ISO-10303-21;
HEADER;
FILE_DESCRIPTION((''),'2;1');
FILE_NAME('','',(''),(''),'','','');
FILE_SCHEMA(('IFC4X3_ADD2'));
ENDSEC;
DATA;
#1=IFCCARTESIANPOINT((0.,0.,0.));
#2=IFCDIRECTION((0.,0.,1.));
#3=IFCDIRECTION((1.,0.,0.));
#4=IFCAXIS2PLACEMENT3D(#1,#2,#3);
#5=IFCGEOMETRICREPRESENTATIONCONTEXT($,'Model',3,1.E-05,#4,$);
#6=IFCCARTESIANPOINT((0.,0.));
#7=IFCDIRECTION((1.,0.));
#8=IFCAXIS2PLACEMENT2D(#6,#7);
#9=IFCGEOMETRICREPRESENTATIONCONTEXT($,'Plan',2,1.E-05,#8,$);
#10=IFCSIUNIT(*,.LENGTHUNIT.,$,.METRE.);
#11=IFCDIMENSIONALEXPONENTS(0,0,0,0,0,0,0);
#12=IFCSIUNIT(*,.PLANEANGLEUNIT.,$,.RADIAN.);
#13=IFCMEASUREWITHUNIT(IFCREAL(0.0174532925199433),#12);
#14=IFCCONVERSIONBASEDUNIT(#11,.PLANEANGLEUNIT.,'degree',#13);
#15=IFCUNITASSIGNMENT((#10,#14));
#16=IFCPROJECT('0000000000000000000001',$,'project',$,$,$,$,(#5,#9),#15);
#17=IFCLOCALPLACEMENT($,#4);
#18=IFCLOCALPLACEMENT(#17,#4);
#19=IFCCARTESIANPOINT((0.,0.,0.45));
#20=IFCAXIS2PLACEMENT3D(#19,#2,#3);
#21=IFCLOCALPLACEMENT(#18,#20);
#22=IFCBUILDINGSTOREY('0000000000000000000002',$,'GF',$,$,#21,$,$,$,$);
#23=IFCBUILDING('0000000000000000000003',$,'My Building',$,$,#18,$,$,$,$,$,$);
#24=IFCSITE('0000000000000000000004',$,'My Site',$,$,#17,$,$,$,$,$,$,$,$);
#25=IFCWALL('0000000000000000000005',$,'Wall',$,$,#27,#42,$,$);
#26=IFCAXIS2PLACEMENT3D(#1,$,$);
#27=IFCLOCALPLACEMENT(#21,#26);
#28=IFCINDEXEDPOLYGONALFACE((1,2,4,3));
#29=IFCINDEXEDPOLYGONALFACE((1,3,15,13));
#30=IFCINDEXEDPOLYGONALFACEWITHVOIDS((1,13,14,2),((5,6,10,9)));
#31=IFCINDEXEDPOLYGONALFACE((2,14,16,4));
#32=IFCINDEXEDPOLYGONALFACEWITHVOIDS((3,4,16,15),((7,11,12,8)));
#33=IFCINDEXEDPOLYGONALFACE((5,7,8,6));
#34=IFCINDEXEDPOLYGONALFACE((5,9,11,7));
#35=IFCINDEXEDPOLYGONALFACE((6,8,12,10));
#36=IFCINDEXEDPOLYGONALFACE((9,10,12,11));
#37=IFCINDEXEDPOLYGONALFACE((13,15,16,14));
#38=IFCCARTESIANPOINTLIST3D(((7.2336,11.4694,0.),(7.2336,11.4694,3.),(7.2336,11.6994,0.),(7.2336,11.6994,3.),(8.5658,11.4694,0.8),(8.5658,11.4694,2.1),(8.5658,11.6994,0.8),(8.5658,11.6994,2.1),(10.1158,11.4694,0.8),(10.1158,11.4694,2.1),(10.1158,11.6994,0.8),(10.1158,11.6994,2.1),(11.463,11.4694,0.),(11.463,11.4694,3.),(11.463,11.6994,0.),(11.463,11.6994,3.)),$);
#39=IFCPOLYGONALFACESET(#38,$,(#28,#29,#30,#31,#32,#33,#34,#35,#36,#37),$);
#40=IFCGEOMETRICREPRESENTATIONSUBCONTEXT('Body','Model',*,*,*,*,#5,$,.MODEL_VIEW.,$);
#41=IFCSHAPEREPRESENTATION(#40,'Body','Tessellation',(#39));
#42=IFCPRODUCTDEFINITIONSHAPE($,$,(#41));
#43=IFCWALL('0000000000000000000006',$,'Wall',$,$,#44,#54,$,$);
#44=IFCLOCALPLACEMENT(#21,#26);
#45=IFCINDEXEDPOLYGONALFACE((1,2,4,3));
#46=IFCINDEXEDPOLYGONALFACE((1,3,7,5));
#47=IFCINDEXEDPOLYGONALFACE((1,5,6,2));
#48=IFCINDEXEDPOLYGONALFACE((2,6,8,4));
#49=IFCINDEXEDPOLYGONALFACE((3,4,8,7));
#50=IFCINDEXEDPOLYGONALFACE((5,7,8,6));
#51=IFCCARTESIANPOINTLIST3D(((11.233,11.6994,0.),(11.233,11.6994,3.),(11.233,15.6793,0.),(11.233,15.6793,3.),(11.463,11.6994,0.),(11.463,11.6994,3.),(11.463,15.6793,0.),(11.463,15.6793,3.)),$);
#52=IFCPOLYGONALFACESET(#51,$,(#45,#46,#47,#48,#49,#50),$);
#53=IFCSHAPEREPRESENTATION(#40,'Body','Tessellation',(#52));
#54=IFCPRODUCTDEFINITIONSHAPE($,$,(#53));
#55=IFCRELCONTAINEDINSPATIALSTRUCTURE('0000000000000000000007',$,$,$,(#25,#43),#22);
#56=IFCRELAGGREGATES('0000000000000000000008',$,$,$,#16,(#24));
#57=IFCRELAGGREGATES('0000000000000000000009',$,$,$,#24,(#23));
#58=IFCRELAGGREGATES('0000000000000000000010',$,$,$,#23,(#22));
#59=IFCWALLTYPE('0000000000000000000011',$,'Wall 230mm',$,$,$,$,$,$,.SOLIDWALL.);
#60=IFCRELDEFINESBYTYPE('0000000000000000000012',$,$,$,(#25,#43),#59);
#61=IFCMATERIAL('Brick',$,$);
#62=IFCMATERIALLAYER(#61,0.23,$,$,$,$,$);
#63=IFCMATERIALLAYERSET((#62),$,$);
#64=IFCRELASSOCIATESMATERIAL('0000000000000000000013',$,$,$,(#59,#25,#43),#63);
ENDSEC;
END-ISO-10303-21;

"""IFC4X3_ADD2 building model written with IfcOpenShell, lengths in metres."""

from ifc_helpers import new_model, entity, si_unit, converted_unit, frame, origin_with_axes, origin_2d_with_axis, place, context, subcontext, project, spatial, line, indexed_curve, outline, extrude, source, transform, mapped, material, layer, layer_set, layer_usage, type_object, element, save


model = new_model("IFC4X3_ADD2")

# Units and contexts
model_context = context("Model", 3, precision=1e-05, world=origin_with_axes())
plan_context = context("Plan", 2, precision=1e-05, world=origin_2d_with_axis())
body_context_1 = subcontext(model_context, "Body", "Model", "MODEL_VIEW")
ifc_project = project(units=[si_unit("LENGTHUNIT", "METRE"), converted_unit("PLANEANGLEUNIT", "degree", entity("IfcReal", 0.0174532925199433), si_unit("PLANEANGLEUNIT", "RADIAN"), dimensions=[0, 0, 0, 0, 0, 0, 0])], contexts=[model_context, plan_context])

# Site, building, storey
site_placement = place(None, origin_with_axes())
site = spatial("IfcSite", under=ifc_project, at=site_placement, Name="My Site")
building_placement = place(site_placement, origin_with_axes())
building = spatial("IfcBuilding", under=site, at=building_placement, Name="My Building")
storey_placement = place(building_placement, frame((0.0, 0.0, 0.45), z_axis=(0.0, 0.0, 1.0), x_axis=(1.0, 0.0, 0.0)))
storey = spatial("IfcBuildingStorey", under=building, at=storey_placement, Name="GF")

# Shared definitions
ifc_material_1 = material(Name="Brick")
ifc_layer_1 = layer(ifc_material_1, 0.23)
ifc_layer_set_1 = layer_set([ifc_layer_1])
wall_type = type_object("IfcWallType", Name="Wall 230mm", PredefinedType="SOLIDWALL", material=ifc_layer_set_1)
shared_shape_1 = source(origin_with_axes(), body_context_1, "Body", "SweptSolid", [
    extrude(outline(indexed_curve([(0.0, 0.0), (1.55, 0.0), (1.55, 1.3), (0.0, 1.3)], segments=[line(1, 2, 3, 4, 1)])), frame((-0.775, -0.6, 0.0), z_axis=(0.0, -1.0, 0.0), x_axis=(1.0, 0.0, 0.0)), (0.0, 0.0, -1.0), 1.2),
])

# Wall, opening
ifc_layer_usage_1 = layer_usage(ifc_layer_set_1, "AXIS2", "POSITIVE", 0.0)
wall_1_placement = place(storey_placement, frame((7.2336, 11.4694, 0.0), z_axis=(0.0, 0.0, 1.0), x_axis=(1.0, 0.0, 0.0)))
wall_1 = element("IfcWall", 1, at=wall_1_placement, inside=storey, type_object=wall_type, material=ifc_layer_usage_1, Name="Wall", context=body_context_1, shape_type="SweptSolid", body=[
    extrude(outline(indexed_curve([(0.0, 0.0), (0.0, 0.23), (4.2294, 0.23), (4.2294, 0.0), (0.0, 0.0)], self_intersect=False)), origin_with_axes(), (0.0, 0.0, 1.0), 3.0),
])
opening_1_placement = place(wall_1_placement, frame((2.1072, 0.0, 0.8), z_axis=(0.0, 0.0, 1.0), x_axis=(1.0, 0.0, 0.0)))
element("IfcOpeningElement", 2, at=opening_1_placement, cuts=wall_1, PredefinedType="OPENING", context=body_context_1, shape_type="MappedRepresentation", body=[
    mapped(shared_shape_1, transform((0.0, 0.0, 0.0), x_axis=(1.0, 0.0, 0.0), y_axis=(0.0, 1.0, 0.0), z_axis=(0.0, 0.0, 1.0), scale=1.0)),
])

# Wall
ifc_layer_usage_2 = layer_usage(ifc_layer_set_1, "AXIS2", "POSITIVE", 0.0)
wall_2_placement = place(storey_placement, frame((11.463, 11.6994, 0.0), z_axis=(0.0, 0.0, 1.0), x_axis=(0.0, 1.0, 0.0)))
element("IfcWall", 3, at=wall_2_placement, inside=storey, type_object=wall_type, material=ifc_layer_usage_2, Name="Wall", context=body_context_1, shape_type="SweptSolid", body=[
    extrude(outline(indexed_curve([(0.0, 0.0), (0.0, 0.23), (3.98, 0.23), (3.98, 0.0), (0.0, 0.0)], self_intersect=False)), origin_with_axes(), (0.0, 0.0, 1.0), 3.0),
])

save(model, "model.ifc")
